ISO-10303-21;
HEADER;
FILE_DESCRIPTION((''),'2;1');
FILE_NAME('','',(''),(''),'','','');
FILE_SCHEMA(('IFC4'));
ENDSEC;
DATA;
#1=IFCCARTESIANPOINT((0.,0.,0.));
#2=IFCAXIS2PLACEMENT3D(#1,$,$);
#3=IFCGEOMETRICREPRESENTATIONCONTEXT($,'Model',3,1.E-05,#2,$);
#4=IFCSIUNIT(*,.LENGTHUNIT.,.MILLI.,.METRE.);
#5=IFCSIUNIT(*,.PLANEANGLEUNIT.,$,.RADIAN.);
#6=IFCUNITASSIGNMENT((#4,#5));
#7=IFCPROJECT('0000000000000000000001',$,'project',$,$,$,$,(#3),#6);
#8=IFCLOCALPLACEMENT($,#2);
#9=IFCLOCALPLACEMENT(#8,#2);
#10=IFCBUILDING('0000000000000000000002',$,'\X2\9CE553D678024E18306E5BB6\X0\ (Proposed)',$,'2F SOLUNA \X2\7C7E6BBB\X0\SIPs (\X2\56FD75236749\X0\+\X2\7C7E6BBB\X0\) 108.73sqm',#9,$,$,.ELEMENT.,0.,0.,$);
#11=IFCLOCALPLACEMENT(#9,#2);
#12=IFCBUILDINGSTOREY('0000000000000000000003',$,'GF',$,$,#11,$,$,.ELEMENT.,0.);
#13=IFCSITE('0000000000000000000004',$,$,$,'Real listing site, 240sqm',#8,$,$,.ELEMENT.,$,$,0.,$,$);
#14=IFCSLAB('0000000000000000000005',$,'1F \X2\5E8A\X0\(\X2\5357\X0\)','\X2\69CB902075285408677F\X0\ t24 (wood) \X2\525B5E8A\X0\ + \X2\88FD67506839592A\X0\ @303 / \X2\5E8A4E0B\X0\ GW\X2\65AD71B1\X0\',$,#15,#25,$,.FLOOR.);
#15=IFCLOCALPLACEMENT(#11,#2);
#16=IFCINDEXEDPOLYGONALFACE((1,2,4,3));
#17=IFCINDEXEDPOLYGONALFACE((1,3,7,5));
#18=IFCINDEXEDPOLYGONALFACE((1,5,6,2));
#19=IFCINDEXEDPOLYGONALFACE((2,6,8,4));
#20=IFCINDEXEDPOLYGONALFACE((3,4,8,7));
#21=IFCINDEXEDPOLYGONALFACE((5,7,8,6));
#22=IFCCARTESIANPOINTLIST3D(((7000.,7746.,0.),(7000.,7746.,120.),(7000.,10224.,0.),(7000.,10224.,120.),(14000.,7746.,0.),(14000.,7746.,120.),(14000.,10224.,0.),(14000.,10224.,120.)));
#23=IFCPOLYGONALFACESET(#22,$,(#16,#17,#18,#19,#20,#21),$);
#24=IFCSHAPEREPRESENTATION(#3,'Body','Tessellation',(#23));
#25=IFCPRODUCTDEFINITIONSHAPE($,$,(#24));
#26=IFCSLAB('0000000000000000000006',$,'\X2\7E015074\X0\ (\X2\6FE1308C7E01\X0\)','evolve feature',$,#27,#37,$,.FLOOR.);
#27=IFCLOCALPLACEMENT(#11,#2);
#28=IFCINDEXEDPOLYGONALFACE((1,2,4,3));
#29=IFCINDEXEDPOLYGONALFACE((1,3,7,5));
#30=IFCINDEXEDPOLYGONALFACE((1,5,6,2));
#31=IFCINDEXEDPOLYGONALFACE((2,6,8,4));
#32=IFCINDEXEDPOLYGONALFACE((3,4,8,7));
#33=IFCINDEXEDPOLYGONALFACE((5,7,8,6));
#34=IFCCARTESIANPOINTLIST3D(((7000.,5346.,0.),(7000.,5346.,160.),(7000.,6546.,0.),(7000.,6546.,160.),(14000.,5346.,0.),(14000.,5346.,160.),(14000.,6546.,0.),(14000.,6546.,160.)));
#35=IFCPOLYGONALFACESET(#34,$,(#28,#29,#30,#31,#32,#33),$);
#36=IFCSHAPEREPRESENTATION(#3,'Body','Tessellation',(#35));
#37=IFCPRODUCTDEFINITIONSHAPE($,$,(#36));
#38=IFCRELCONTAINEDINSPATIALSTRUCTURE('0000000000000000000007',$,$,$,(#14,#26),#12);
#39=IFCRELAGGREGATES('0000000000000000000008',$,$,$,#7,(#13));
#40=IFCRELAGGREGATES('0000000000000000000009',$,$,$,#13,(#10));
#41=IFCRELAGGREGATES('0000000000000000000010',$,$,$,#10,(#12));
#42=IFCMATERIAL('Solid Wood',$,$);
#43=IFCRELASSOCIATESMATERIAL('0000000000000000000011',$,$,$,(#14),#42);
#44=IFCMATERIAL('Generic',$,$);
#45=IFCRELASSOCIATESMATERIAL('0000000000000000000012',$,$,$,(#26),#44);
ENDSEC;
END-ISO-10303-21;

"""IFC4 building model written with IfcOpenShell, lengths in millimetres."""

from ifc_helpers import new_model, si_unit, frame, frame_2d, origin, place, context, project, spatial, rectangle, extrude, material, element, save


model = new_model("IFC4")

# Units and contexts
model_context = context("Model", 3, precision=1e-05, world=origin())
ifc_project = project(units=[si_unit("LENGTHUNIT", "METRE", prefix="MILLI"), si_unit("PLANEANGLEUNIT", "RADIAN")], contexts=[model_context])

# Site, building, storey
site_placement = place(None, origin())
site = spatial("IfcSite", under=ifc_project, at=site_placement, ObjectType="Real listing site, 240sqm", CompositionType="ELEMENT", RefElevation=0.0)
building_placement = place(site_placement, origin())
building = spatial("IfcBuilding", under=site, at=building_placement, Name="鳥取砂丘の家 (Proposed)", ObjectType="2F SOLUNA 籾殻SIPs (国産杉+籾殻) 108.73sqm", CompositionType="ELEMENT", ElevationOfRefHeight=0.0, ElevationOfTerrain=0.0)
storey_placement = place(building_placement, origin())
storey = spatial("IfcBuildingStorey", under=building, at=storey_placement, Name="GF", CompositionType="ELEMENT", Elevation=0.0)

# Slabs
ifc_material_1 = material(Name="Solid Wood")
slab_1_placement = place(storey_placement, frame((3500.0, 3873.0, 0.0)))
element("IfcSlab", 1, at=slab_1_placement, inside=storey, material=ifc_material_1, Name="1F 床(南)", Description="構造用合板 t24 (wood) 剛床 + 製材根太 @303 / 床下 GW断熱", PredefinedType="FLOOR", context=model_context, shape_type="SweptSolid", body=[
    extrude(rectangle(XDim=7000.0, YDim=2478.0, at=frame_2d((3500.0, 1239.0))), frame((3500.0, 3873.0, 0.0)), (0.0, 0.0, 1.0), 120.0),
])
ifc_material_2 = material(Name="Generic")
slab_2_placement = place(storey_placement, frame((3500.0, 2673.0, 0.0)))
element("IfcSlab", 2, at=slab_2_placement, inside=storey, material=ifc_material_2, Name="縁側 (濡れ縁)", Description="evolve feature", PredefinedType="FLOOR", context=model_context, shape_type="SweptSolid", body=[
    extrude(rectangle(XDim=7000.0, YDim=1200.0, at=frame_2d((3500.0, 600.0))), frame((3500.0, 2673.0, 0.0)), (0.0, 0.0, 1.0), 160.0),
])

save(model, "model.ifc")
